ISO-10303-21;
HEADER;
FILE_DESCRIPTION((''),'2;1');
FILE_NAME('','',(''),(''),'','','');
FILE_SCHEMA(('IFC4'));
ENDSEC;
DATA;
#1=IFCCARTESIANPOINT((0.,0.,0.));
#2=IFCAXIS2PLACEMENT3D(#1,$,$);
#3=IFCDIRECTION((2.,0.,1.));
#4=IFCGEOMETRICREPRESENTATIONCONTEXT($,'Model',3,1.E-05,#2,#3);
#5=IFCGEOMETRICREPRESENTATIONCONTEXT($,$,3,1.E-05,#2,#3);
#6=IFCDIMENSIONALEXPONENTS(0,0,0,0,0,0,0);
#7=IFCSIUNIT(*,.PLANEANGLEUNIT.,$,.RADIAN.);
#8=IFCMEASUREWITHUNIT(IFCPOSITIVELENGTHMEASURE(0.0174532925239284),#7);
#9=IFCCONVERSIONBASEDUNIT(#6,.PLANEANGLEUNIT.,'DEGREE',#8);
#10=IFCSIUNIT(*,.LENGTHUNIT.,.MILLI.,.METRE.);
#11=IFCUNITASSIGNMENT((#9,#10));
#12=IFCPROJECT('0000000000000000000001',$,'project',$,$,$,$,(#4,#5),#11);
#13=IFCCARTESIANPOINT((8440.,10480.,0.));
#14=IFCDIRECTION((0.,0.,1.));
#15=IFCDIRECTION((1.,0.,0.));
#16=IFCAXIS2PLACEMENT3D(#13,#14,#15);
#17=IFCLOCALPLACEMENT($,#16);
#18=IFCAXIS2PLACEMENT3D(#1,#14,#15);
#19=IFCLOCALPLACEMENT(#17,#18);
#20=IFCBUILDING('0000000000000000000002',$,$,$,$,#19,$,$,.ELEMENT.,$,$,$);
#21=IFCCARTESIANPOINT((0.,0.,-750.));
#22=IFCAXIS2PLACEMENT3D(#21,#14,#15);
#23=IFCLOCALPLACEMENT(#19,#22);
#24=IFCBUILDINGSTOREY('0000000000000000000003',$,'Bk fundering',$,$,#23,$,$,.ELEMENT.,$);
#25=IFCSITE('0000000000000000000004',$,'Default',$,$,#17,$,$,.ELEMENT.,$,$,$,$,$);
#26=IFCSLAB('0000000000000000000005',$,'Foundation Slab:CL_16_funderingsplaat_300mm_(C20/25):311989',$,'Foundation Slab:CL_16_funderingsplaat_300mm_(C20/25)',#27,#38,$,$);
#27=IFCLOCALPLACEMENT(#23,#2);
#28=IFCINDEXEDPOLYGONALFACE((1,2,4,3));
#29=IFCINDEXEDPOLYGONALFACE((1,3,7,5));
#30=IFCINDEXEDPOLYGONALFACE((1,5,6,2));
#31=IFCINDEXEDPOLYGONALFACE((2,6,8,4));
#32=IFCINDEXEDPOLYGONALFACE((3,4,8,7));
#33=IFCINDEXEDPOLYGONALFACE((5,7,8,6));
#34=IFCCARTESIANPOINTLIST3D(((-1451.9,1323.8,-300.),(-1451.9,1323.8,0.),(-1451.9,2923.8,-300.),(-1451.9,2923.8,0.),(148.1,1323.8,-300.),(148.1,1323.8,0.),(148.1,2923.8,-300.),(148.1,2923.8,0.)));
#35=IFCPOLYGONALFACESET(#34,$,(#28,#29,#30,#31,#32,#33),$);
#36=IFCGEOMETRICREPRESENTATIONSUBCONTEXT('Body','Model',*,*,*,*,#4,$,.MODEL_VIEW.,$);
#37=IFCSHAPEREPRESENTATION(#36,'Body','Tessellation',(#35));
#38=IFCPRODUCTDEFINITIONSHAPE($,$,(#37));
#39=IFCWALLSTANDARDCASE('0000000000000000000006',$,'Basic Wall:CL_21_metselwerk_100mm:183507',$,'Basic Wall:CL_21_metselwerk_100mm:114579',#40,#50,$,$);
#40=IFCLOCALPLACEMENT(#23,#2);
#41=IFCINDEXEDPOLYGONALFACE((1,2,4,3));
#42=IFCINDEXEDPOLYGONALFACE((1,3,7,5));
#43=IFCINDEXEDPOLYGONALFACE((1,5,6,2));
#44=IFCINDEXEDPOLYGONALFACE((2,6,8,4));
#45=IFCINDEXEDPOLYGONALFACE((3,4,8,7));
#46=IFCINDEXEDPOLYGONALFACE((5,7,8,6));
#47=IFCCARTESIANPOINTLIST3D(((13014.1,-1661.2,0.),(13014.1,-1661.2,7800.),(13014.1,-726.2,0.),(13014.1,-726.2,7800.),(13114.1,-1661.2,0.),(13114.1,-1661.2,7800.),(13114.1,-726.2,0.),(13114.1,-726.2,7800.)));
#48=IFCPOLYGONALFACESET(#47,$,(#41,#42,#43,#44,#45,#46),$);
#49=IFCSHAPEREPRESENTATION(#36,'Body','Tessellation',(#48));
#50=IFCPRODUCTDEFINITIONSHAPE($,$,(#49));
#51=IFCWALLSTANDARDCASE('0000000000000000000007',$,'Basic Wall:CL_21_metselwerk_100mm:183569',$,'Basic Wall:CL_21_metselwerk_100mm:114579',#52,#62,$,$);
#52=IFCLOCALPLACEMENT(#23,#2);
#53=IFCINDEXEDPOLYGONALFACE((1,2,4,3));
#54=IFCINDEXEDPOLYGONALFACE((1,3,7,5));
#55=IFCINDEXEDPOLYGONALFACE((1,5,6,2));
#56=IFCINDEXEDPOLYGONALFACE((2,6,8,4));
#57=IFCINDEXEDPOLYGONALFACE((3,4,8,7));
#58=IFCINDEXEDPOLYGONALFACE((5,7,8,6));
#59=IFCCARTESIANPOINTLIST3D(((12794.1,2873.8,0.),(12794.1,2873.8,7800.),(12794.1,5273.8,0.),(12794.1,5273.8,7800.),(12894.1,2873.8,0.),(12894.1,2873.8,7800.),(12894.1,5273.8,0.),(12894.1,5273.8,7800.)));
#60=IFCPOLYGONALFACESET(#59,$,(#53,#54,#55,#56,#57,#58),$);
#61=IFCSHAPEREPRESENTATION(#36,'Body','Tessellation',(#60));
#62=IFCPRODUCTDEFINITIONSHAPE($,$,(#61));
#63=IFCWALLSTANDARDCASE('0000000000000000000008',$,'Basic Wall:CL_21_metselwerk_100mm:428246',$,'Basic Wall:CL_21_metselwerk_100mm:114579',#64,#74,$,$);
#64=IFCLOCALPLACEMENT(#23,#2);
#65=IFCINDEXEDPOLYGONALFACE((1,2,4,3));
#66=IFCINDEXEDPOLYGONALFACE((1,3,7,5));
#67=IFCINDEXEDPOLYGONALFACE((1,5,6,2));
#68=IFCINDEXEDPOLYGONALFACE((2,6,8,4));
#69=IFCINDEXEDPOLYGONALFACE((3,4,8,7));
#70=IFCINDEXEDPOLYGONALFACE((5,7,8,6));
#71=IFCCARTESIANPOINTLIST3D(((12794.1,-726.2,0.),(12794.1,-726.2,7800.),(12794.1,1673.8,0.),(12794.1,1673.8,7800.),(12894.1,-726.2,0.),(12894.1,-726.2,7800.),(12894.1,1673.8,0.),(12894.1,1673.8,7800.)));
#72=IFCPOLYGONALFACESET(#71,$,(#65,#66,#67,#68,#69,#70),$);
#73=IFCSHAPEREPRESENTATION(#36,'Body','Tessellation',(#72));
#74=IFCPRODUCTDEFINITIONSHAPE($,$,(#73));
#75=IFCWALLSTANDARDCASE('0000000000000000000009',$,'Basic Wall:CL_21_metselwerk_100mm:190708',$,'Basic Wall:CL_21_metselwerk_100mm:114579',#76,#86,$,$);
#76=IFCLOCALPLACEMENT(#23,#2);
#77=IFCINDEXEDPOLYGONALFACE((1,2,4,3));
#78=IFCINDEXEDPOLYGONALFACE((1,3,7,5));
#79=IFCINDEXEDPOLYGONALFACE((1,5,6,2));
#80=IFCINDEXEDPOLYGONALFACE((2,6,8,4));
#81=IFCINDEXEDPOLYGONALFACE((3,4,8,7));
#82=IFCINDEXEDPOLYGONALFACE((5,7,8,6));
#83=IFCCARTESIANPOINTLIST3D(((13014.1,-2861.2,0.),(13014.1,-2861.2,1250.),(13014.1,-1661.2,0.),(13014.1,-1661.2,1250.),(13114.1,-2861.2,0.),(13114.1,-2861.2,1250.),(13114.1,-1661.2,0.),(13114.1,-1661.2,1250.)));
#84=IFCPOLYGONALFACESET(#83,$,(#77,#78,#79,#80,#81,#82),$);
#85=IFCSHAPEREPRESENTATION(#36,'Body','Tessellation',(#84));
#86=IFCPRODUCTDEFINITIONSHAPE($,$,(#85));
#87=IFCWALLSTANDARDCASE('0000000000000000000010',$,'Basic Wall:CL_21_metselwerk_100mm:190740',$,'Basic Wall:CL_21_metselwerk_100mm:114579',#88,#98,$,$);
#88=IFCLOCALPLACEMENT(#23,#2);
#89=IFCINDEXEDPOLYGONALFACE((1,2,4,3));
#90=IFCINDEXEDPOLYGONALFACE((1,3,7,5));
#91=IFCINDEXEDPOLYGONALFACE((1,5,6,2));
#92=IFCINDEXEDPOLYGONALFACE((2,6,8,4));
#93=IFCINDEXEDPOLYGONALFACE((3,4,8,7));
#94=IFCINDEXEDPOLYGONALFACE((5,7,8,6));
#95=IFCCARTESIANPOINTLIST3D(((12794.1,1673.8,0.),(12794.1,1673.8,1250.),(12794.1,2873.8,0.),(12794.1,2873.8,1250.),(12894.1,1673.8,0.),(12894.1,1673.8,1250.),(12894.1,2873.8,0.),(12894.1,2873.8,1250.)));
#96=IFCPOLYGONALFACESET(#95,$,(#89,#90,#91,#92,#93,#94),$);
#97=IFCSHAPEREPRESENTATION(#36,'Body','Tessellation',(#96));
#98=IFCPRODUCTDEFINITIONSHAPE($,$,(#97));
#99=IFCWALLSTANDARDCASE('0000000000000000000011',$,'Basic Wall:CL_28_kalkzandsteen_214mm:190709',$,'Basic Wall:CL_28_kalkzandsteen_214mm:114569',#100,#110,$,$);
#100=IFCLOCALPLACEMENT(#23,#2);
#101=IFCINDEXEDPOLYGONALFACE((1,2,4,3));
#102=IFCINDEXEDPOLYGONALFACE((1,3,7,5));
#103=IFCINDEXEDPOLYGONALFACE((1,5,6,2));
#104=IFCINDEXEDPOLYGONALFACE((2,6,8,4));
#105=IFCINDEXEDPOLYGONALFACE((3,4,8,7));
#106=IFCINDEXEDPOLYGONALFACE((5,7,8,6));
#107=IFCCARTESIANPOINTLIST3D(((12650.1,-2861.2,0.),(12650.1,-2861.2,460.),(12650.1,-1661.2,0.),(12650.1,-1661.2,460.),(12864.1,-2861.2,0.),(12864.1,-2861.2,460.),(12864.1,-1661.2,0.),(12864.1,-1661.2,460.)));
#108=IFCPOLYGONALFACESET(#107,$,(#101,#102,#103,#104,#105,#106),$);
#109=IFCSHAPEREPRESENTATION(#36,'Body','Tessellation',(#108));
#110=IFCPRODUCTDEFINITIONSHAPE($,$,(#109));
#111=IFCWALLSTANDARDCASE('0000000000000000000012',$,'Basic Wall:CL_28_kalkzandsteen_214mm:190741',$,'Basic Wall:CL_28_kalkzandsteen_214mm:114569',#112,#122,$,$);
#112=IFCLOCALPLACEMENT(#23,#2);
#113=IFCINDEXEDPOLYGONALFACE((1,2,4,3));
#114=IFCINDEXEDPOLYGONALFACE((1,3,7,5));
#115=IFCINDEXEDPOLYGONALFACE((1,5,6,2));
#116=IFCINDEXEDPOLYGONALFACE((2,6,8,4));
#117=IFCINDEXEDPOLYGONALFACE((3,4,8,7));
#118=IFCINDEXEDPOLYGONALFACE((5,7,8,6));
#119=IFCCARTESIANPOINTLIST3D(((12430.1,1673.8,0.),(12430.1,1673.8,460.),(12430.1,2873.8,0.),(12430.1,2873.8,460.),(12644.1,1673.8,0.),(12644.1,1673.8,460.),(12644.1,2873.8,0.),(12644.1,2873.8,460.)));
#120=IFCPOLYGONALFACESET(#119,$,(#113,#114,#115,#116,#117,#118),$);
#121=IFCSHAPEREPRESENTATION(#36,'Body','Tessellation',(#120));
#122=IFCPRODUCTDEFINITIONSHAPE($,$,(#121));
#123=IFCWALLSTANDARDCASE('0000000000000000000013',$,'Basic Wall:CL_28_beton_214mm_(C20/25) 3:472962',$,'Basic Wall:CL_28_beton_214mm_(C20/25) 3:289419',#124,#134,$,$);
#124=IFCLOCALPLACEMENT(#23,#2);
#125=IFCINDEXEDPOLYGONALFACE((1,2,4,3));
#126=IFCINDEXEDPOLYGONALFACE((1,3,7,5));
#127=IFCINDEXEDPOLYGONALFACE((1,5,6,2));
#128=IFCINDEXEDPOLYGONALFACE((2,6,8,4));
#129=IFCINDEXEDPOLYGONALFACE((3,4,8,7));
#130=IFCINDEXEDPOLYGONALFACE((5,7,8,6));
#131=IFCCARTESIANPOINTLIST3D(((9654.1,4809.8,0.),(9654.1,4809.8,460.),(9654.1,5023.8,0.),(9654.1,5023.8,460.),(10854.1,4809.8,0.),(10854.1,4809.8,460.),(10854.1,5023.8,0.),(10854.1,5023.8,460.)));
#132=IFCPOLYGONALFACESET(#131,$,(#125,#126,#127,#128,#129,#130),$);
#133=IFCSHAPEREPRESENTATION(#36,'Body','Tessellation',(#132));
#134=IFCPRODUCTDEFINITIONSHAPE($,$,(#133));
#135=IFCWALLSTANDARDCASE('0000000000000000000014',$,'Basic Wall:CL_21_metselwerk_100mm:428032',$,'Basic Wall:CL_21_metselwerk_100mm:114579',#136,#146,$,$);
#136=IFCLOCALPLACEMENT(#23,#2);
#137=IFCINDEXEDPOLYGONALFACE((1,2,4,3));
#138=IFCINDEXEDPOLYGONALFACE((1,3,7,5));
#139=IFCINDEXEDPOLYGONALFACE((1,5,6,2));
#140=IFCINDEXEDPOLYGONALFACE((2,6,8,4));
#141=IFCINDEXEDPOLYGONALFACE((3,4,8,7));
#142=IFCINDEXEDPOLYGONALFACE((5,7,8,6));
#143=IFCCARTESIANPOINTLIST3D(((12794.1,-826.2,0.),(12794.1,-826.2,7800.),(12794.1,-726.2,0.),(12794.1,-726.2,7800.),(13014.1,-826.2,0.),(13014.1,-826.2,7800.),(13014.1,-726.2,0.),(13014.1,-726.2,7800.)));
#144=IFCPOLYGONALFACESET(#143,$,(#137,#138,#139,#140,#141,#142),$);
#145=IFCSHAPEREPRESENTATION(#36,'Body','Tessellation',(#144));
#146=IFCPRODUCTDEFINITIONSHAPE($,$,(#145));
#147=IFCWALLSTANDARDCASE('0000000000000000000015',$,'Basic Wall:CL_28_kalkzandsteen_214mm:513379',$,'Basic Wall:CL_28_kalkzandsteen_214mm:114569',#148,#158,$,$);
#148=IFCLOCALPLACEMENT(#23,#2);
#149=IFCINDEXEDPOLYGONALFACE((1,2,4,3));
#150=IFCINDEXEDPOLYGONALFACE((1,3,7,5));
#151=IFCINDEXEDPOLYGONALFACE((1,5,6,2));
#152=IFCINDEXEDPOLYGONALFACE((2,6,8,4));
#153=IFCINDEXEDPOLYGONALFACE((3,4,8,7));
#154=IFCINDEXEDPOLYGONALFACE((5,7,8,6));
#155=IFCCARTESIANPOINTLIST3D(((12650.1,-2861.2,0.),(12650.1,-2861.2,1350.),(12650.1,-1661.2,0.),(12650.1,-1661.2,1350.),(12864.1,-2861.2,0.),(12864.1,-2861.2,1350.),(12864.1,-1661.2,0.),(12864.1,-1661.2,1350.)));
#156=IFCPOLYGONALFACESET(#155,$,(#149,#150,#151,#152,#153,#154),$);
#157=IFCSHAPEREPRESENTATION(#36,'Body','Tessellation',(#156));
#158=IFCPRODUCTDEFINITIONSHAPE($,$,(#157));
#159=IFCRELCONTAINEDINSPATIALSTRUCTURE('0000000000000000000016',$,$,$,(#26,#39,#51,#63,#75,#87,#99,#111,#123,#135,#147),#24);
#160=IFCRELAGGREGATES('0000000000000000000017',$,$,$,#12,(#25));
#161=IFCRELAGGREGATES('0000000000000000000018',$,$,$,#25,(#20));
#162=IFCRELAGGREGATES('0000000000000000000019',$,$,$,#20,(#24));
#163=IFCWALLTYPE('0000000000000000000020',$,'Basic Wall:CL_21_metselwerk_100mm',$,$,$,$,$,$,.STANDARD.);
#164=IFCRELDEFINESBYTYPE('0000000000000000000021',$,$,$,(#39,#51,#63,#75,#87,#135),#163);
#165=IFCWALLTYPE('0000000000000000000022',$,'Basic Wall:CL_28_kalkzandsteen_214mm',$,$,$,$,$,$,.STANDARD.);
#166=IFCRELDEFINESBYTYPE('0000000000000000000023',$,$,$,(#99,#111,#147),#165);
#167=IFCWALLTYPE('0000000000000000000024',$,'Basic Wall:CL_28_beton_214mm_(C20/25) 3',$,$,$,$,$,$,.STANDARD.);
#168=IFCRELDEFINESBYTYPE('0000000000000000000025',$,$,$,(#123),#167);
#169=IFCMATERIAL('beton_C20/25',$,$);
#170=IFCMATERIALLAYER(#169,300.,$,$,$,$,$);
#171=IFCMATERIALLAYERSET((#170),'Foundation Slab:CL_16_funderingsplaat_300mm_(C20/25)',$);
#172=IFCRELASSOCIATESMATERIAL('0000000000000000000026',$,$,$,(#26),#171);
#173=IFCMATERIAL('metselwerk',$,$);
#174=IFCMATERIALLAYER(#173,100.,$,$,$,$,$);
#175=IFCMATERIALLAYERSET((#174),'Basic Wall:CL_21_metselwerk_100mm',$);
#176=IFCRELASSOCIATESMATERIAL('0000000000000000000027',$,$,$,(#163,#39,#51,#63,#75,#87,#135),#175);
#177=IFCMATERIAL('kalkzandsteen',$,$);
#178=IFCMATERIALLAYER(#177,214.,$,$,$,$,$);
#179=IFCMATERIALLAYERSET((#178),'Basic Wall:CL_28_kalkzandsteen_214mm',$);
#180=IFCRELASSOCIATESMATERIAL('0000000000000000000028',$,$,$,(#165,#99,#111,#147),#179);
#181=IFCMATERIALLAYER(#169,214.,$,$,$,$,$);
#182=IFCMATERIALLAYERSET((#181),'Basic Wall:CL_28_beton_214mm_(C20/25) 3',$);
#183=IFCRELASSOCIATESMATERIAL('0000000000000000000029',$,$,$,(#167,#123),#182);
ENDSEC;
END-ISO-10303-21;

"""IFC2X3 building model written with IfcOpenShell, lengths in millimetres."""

from ifc_helpers import new_model, entity, si_unit, converted_unit, direction, frame, frame_2d, origin, origin_with_axes, place, context, subcontext, project, spatial, polyline, rectangle, extrude, clip, bounded_halfspace, source, transform, mapped, material, layer, layer_set, layer_usage, type_object, element, save


model = new_model("IFC2X3")

# Units and contexts
model_context = context("Model", 3, precision=1e-05, world=origin(), true_north=direction((2.0, 0.0, 1.0)))
context_of_model = context(None, 3, precision=1e-05, world=origin(), true_north=direction((2.0, 0.0, 1.0)))
body_context = subcontext(model_context, "Body", "Model", "MODEL_VIEW")
ifc_project = project(units=[converted_unit("PLANEANGLEUNIT", "DEGREE", entity("IfcPositiveLengthMeasure", 0.0174532925239284), si_unit("PLANEANGLEUNIT", "RADIAN"), dimensions=[0, 0, 0, 0, 0, 0, 0]), si_unit("LENGTHUNIT", "METRE", prefix="MILLI")], contexts=[model_context, context_of_model])

# Site, building, storey
site_placement = place(None, frame((8440.0, 10480.0, 0.0), z_axis=(0.0, 0.0, 1.0), x_axis=(1.0, 0.0, 0.0)))
site = spatial("IfcSite", under=ifc_project, at=site_placement, Name="Default", CompositionType="ELEMENT")
building_placement = place(site_placement, origin_with_axes())
building = spatial("IfcBuilding", under=site, at=building_placement, CompositionType="ELEMENT")
storey_placement = place(building_placement, frame((0.0, 0.0, -750.0), z_axis=(0.0, 0.0, 1.0), x_axis=(1.0, 0.0, 0.0)))
storey = spatial("IfcBuildingStorey", under=building, at=storey_placement, Name="Bk fundering", CompositionType="ELEMENT")

# Slab
ifc_material_1 = material(Name="beton_C20/25")
ifc_layer_1 = layer(ifc_material_1, 300.0)
ifc_layer_set_1 = layer_set([ifc_layer_1], Name="Foundation Slab:CL_16_funderingsplaat_300mm_(C20/25)")
ifc_layer_usage_1 = layer_usage(ifc_layer_set_1, "AXIS3", "POSITIVE", 0.0)
slab_placement = place(storey_placement, origin_with_axes())
element("IfcSlab", 1, at=slab_placement, inside=storey, material=ifc_layer_usage_1, Name="Foundation Slab:CL_16_funderingsplaat_300mm_(C20/25):311989", ObjectType="Foundation Slab:CL_16_funderingsplaat_300mm_(C20/25)", context=body_context, shape_type="SweptSolid", body=[
    extrude(rectangle(XDim=1600.0, YDim=1600.0, at=frame_2d((0.0, 0.0), x_axis=(1.0, 0.0))), frame((-651.9, 2123.8, 0.0), z_axis=(0.0, 0.0, -1.0), x_axis=(0.0, 1.0, 0.0)), (0.0, 0.0, 1.0), 300.0),
])

# Walls
ifc_material_2 = material(Name="metselwerk")
ifc_layer_2 = layer(ifc_material_2, 100.0)
ifc_layer_set_2 = layer_set([ifc_layer_2], Name="Basic Wall:CL_21_metselwerk_100mm")
ifc_layer_usage_2 = layer_usage(ifc_layer_set_2, "AXIS2", "NEGATIVE", 50.0)
wall_type_1 = type_object("IfcWallType", Name="Basic Wall:CL_21_metselwerk_100mm", PredefinedType="STANDARD", material=ifc_layer_set_2)
shared_shape_1 = source(origin(), body_context, "Body", "SweptSolid", [
    extrude(rectangle(XDim=935.0, YDim=100.0, at=frame_2d((467.5, 0.0), x_axis=(-1.0, 0.0))), origin(), (0.0, 0.0, 1.0), 7800.0),
])
wall_1_placement = place(storey_placement, frame((13064.1, -1661.2, 0.0), z_axis=(0.0, 0.0, 1.0), x_axis=(0.0, 1.0, 0.0)))
element("IfcWallStandardCase", 2, at=wall_1_placement, inside=storey, type_object=wall_type_1, material=ifc_layer_usage_2, Name="Basic Wall:CL_21_metselwerk_100mm:183507", ObjectType="Basic Wall:CL_21_metselwerk_100mm:114579", context=body_context, shape_type="MappedRepresentation", body=[
    mapped(shared_shape_1, transform((0.0, 0.0, 0.0))),
])
ifc_layer_usage_3 = layer_usage(ifc_layer_set_2, "AXIS2", "NEGATIVE", 50.0)
shared_shape_2 = source(origin(), body_context, "Body", "SweptSolid", [
    extrude(rectangle(XDim=2400.0, YDim=100.0, at=frame_2d((1200.0, 0.0), x_axis=(-1.0, 0.0))), origin(), (0.0, 0.0, 1.0), 7800.0),
])
wall_2_placement = place(storey_placement, frame((12844.1, 2873.8, 0.0), z_axis=(0.0, 0.0, 1.0), x_axis=(0.0, 1.0, 0.0)))
element("IfcWallStandardCase", 3, at=wall_2_placement, inside=storey, type_object=wall_type_1, material=ifc_layer_usage_3, Name="Basic Wall:CL_21_metselwerk_100mm:183569", ObjectType="Basic Wall:CL_21_metselwerk_100mm:114579", context=body_context, shape_type="MappedRepresentation", body=[
    mapped(shared_shape_2, transform((0.0, 0.0, 0.0))),
])
ifc_layer_usage_4 = layer_usage(ifc_layer_set_2, "AXIS2", "NEGATIVE", 50.0)
wall_3_placement = place(storey_placement, frame((12844.1, -726.2, 0.0), z_axis=(0.0, 0.0, 1.0), x_axis=(0.0, 1.0, 0.0)))
element("IfcWallStandardCase", 4, at=wall_3_placement, inside=storey, type_object=wall_type_1, material=ifc_layer_usage_4, Name="Basic Wall:CL_21_metselwerk_100mm:428246", ObjectType="Basic Wall:CL_21_metselwerk_100mm:114579", context=body_context, shape_type="MappedRepresentation", body=[
    mapped(shared_shape_2, transform((0.0, 0.0, 0.0))),
])
ifc_layer_usage_5 = layer_usage(ifc_layer_set_2, "AXIS2", "NEGATIVE", 50.0)
shared_shape_3 = source(origin(), body_context, "Body", "SweptSolid", [
    extrude(rectangle(XDim=1200.0, YDim=100.0, at=frame_2d((600.0, 0.0), x_axis=(-1.0, 0.0))), origin(), (0.0, 0.0, 1.0), 1250.0),
])
wall_4_placement = place(storey_placement, frame((13064.1, -2861.2, 0.0), z_axis=(0.0, 0.0, 1.0), x_axis=(0.0, 1.0, 0.0)))
element("IfcWallStandardCase", 5, at=wall_4_placement, inside=storey, type_object=wall_type_1, material=ifc_layer_usage_5, Name="Basic Wall:CL_21_metselwerk_100mm:190708", ObjectType="Basic Wall:CL_21_metselwerk_100mm:114579", context=body_context, shape_type="MappedRepresentation", body=[
    mapped(shared_shape_3, transform((0.0, 0.0, 0.0))),
])
ifc_layer_usage_6 = layer_usage(ifc_layer_set_2, "AXIS2", "NEGATIVE", 50.0)
wall_5_placement = place(storey_placement, frame((12844.1, 1673.8, 0.0), z_axis=(0.0, 0.0, 1.0), x_axis=(0.0, 1.0, 0.0)))
element("IfcWallStandardCase", 6, at=wall_5_placement, inside=storey, type_object=wall_type_1, material=ifc_layer_usage_6, Name="Basic Wall:CL_21_metselwerk_100mm:190740", ObjectType="Basic Wall:CL_21_metselwerk_100mm:114579", context=body_context, shape_type="MappedRepresentation", body=[
    mapped(shared_shape_3, transform((0.0, 0.0, 0.0))),
])
ifc_material_3 = material(Name="kalkzandsteen")
ifc_layer_3 = layer(ifc_material_3, 214.0)
ifc_layer_set_3 = layer_set([ifc_layer_3], Name="Basic Wall:CL_28_kalkzandsteen_214mm")
ifc_layer_usage_7 = layer_usage(ifc_layer_set_3, "AXIS2", "NEGATIVE", 107.0)
wall_type_2 = type_object("IfcWallType", Name="Basic Wall:CL_28_kalkzandsteen_214mm", PredefinedType="STANDARD", material=ifc_layer_set_3)
shared_shape_4 = source(origin(), body_context, "Body", "Clipping", [
    clip(extrude(rectangle(XDim=1200.0, YDim=214.0, at=frame_2d((600.0, 0.0), x_axis=(-1.0, 0.0))), origin(), (0.0, 0.0, 1.0), 460.0), bounded_halfspace(frame((0.0, -107.0, 460.0), z_axis=(0.0, 0.0, -1.0), x_axis=(0.0, -1.0, 0.0)), True, frame((0.0, -107.0, 460.0)), polyline([(0.0, 0.0), (1200.0, 0.0), (1200.0, 214.0), (0.0, 214.0), (0.0, 0.0)]))),
])
wall_6_placement = place(storey_placement, frame((12757.1, -2861.2, 0.0), z_axis=(0.0, 0.0, 1.0), x_axis=(0.0, 1.0, 0.0)))
element("IfcWallStandardCase", 7, at=wall_6_placement, inside=storey, type_object=wall_type_2, material=ifc_layer_usage_7, Name="Basic Wall:CL_28_kalkzandsteen_214mm:190709", ObjectType="Basic Wall:CL_28_kalkzandsteen_214mm:114569", context=body_context, shape_type="MappedRepresentation", body=[
    mapped(shared_shape_4, transform((0.0, 0.0, 0.0))),
])
ifc_layer_usage_8 = layer_usage(ifc_layer_set_3, "AXIS2", "NEGATIVE", 107.0)
wall_7_placement = place(storey_placement, frame((12537.1, 1673.8, 0.0), z_axis=(0.0, 0.0, 1.0), x_axis=(0.0, 1.0, 0.0)))
element("IfcWallStandardCase", 8, at=wall_7_placement, inside=storey, type_object=wall_type_2, material=ifc_layer_usage_8, Name="Basic Wall:CL_28_kalkzandsteen_214mm:190741", ObjectType="Basic Wall:CL_28_kalkzandsteen_214mm:114569", context=body_context, shape_type="MappedRepresentation", body=[
    mapped(shared_shape_4, transform((0.0, 0.0, 0.0))),
])
ifc_layer_4 = layer(ifc_material_1, 214.0)
ifc_layer_set_4 = layer_set([ifc_layer_4], Name="Basic Wall:CL_28_beton_214mm_(C20/25) 3")
ifc_layer_usage_9 = layer_usage(ifc_layer_set_4, "AXIS2", "NEGATIVE", 107.0)
wall_type_3 = type_object("IfcWallType", Name="Basic Wall:CL_28_beton_214mm_(C20/25) 3", PredefinedType="STANDARD", material=ifc_layer_set_4)
wall_8_placement = place(storey_placement, frame((9654.1, 4916.8, 0.0), z_axis=(0.0, 0.0, 1.0), x_axis=(1.0, 0.0, 0.0)))
element("IfcWallStandardCase", 9, at=wall_8_placement, inside=storey, type_object=wall_type_3, material=ifc_layer_usage_9, Name="Basic Wall:CL_28_beton_214mm_(C20/25) 3:472962", ObjectType="Basic Wall:CL_28_beton_214mm_(C20/25) 3:289419", context=body_context, shape_type="MappedRepresentation", body=[
    mapped(shared_shape_4, transform((0.0, 0.0, 0.0))),
])
ifc_layer_usage_10 = layer_usage(ifc_layer_set_2, "AXIS2", "NEGATIVE", 50.0)
shared_shape_5 = source(origin(), body_context, "Body", "SweptSolid", [
    extrude(rectangle(XDim=220.0, YDim=100.0, at=frame_2d((110.0, 0.0), x_axis=(-1.0, 0.0))), origin(), (0.0, 0.0, 1.0), 7800.0),
])
wall_9_placement = place(storey_placement, frame((13014.1, -776.2, 0.0), z_axis=(0.0, 0.0, 1.0), x_axis=(-1.0, 0.0, 0.0)))
element("IfcWallStandardCase", 10, at=wall_9_placement, inside=storey, type_object=wall_type_1, material=ifc_layer_usage_10, Name="Basic Wall:CL_21_metselwerk_100mm:428032", ObjectType="Basic Wall:CL_21_metselwerk_100mm:114579", context=body_context, shape_type="MappedRepresentation", body=[
    mapped(shared_shape_5, transform((0.0, 0.0, 0.0))),
])
ifc_layer_usage_11 = layer_usage(ifc_layer_set_3, "AXIS2", "NEGATIVE", 107.0)
shared_shape_6 = source(origin(), body_context, "Body", "SweptSolid", [
    extrude(rectangle(XDim=1200.0, YDim=214.0, at=frame_2d((600.0, 0.0), x_axis=(-1.0, 0.0))), origin(), (0.0, 0.0, 1.0), 1350.0),
])
wall_10_placement = place(storey_placement, frame((12757.1, -2861.2, 0.0), z_axis=(0.0, 0.0, 1.0), x_axis=(0.0, 1.0, 0.0)))
element("IfcWallStandardCase", 11, at=wall_10_placement, inside=storey, type_object=wall_type_2, material=ifc_layer_usage_11, Name="Basic Wall:CL_28_kalkzandsteen_214mm:513379", ObjectType="Basic Wall:CL_28_kalkzandsteen_214mm:114569", context=body_context, shape_type="MappedRepresentation", body=[
    mapped(shared_shape_6, transform((0.0, 0.0, 0.0))),
])

save(model, "model.ifc")
